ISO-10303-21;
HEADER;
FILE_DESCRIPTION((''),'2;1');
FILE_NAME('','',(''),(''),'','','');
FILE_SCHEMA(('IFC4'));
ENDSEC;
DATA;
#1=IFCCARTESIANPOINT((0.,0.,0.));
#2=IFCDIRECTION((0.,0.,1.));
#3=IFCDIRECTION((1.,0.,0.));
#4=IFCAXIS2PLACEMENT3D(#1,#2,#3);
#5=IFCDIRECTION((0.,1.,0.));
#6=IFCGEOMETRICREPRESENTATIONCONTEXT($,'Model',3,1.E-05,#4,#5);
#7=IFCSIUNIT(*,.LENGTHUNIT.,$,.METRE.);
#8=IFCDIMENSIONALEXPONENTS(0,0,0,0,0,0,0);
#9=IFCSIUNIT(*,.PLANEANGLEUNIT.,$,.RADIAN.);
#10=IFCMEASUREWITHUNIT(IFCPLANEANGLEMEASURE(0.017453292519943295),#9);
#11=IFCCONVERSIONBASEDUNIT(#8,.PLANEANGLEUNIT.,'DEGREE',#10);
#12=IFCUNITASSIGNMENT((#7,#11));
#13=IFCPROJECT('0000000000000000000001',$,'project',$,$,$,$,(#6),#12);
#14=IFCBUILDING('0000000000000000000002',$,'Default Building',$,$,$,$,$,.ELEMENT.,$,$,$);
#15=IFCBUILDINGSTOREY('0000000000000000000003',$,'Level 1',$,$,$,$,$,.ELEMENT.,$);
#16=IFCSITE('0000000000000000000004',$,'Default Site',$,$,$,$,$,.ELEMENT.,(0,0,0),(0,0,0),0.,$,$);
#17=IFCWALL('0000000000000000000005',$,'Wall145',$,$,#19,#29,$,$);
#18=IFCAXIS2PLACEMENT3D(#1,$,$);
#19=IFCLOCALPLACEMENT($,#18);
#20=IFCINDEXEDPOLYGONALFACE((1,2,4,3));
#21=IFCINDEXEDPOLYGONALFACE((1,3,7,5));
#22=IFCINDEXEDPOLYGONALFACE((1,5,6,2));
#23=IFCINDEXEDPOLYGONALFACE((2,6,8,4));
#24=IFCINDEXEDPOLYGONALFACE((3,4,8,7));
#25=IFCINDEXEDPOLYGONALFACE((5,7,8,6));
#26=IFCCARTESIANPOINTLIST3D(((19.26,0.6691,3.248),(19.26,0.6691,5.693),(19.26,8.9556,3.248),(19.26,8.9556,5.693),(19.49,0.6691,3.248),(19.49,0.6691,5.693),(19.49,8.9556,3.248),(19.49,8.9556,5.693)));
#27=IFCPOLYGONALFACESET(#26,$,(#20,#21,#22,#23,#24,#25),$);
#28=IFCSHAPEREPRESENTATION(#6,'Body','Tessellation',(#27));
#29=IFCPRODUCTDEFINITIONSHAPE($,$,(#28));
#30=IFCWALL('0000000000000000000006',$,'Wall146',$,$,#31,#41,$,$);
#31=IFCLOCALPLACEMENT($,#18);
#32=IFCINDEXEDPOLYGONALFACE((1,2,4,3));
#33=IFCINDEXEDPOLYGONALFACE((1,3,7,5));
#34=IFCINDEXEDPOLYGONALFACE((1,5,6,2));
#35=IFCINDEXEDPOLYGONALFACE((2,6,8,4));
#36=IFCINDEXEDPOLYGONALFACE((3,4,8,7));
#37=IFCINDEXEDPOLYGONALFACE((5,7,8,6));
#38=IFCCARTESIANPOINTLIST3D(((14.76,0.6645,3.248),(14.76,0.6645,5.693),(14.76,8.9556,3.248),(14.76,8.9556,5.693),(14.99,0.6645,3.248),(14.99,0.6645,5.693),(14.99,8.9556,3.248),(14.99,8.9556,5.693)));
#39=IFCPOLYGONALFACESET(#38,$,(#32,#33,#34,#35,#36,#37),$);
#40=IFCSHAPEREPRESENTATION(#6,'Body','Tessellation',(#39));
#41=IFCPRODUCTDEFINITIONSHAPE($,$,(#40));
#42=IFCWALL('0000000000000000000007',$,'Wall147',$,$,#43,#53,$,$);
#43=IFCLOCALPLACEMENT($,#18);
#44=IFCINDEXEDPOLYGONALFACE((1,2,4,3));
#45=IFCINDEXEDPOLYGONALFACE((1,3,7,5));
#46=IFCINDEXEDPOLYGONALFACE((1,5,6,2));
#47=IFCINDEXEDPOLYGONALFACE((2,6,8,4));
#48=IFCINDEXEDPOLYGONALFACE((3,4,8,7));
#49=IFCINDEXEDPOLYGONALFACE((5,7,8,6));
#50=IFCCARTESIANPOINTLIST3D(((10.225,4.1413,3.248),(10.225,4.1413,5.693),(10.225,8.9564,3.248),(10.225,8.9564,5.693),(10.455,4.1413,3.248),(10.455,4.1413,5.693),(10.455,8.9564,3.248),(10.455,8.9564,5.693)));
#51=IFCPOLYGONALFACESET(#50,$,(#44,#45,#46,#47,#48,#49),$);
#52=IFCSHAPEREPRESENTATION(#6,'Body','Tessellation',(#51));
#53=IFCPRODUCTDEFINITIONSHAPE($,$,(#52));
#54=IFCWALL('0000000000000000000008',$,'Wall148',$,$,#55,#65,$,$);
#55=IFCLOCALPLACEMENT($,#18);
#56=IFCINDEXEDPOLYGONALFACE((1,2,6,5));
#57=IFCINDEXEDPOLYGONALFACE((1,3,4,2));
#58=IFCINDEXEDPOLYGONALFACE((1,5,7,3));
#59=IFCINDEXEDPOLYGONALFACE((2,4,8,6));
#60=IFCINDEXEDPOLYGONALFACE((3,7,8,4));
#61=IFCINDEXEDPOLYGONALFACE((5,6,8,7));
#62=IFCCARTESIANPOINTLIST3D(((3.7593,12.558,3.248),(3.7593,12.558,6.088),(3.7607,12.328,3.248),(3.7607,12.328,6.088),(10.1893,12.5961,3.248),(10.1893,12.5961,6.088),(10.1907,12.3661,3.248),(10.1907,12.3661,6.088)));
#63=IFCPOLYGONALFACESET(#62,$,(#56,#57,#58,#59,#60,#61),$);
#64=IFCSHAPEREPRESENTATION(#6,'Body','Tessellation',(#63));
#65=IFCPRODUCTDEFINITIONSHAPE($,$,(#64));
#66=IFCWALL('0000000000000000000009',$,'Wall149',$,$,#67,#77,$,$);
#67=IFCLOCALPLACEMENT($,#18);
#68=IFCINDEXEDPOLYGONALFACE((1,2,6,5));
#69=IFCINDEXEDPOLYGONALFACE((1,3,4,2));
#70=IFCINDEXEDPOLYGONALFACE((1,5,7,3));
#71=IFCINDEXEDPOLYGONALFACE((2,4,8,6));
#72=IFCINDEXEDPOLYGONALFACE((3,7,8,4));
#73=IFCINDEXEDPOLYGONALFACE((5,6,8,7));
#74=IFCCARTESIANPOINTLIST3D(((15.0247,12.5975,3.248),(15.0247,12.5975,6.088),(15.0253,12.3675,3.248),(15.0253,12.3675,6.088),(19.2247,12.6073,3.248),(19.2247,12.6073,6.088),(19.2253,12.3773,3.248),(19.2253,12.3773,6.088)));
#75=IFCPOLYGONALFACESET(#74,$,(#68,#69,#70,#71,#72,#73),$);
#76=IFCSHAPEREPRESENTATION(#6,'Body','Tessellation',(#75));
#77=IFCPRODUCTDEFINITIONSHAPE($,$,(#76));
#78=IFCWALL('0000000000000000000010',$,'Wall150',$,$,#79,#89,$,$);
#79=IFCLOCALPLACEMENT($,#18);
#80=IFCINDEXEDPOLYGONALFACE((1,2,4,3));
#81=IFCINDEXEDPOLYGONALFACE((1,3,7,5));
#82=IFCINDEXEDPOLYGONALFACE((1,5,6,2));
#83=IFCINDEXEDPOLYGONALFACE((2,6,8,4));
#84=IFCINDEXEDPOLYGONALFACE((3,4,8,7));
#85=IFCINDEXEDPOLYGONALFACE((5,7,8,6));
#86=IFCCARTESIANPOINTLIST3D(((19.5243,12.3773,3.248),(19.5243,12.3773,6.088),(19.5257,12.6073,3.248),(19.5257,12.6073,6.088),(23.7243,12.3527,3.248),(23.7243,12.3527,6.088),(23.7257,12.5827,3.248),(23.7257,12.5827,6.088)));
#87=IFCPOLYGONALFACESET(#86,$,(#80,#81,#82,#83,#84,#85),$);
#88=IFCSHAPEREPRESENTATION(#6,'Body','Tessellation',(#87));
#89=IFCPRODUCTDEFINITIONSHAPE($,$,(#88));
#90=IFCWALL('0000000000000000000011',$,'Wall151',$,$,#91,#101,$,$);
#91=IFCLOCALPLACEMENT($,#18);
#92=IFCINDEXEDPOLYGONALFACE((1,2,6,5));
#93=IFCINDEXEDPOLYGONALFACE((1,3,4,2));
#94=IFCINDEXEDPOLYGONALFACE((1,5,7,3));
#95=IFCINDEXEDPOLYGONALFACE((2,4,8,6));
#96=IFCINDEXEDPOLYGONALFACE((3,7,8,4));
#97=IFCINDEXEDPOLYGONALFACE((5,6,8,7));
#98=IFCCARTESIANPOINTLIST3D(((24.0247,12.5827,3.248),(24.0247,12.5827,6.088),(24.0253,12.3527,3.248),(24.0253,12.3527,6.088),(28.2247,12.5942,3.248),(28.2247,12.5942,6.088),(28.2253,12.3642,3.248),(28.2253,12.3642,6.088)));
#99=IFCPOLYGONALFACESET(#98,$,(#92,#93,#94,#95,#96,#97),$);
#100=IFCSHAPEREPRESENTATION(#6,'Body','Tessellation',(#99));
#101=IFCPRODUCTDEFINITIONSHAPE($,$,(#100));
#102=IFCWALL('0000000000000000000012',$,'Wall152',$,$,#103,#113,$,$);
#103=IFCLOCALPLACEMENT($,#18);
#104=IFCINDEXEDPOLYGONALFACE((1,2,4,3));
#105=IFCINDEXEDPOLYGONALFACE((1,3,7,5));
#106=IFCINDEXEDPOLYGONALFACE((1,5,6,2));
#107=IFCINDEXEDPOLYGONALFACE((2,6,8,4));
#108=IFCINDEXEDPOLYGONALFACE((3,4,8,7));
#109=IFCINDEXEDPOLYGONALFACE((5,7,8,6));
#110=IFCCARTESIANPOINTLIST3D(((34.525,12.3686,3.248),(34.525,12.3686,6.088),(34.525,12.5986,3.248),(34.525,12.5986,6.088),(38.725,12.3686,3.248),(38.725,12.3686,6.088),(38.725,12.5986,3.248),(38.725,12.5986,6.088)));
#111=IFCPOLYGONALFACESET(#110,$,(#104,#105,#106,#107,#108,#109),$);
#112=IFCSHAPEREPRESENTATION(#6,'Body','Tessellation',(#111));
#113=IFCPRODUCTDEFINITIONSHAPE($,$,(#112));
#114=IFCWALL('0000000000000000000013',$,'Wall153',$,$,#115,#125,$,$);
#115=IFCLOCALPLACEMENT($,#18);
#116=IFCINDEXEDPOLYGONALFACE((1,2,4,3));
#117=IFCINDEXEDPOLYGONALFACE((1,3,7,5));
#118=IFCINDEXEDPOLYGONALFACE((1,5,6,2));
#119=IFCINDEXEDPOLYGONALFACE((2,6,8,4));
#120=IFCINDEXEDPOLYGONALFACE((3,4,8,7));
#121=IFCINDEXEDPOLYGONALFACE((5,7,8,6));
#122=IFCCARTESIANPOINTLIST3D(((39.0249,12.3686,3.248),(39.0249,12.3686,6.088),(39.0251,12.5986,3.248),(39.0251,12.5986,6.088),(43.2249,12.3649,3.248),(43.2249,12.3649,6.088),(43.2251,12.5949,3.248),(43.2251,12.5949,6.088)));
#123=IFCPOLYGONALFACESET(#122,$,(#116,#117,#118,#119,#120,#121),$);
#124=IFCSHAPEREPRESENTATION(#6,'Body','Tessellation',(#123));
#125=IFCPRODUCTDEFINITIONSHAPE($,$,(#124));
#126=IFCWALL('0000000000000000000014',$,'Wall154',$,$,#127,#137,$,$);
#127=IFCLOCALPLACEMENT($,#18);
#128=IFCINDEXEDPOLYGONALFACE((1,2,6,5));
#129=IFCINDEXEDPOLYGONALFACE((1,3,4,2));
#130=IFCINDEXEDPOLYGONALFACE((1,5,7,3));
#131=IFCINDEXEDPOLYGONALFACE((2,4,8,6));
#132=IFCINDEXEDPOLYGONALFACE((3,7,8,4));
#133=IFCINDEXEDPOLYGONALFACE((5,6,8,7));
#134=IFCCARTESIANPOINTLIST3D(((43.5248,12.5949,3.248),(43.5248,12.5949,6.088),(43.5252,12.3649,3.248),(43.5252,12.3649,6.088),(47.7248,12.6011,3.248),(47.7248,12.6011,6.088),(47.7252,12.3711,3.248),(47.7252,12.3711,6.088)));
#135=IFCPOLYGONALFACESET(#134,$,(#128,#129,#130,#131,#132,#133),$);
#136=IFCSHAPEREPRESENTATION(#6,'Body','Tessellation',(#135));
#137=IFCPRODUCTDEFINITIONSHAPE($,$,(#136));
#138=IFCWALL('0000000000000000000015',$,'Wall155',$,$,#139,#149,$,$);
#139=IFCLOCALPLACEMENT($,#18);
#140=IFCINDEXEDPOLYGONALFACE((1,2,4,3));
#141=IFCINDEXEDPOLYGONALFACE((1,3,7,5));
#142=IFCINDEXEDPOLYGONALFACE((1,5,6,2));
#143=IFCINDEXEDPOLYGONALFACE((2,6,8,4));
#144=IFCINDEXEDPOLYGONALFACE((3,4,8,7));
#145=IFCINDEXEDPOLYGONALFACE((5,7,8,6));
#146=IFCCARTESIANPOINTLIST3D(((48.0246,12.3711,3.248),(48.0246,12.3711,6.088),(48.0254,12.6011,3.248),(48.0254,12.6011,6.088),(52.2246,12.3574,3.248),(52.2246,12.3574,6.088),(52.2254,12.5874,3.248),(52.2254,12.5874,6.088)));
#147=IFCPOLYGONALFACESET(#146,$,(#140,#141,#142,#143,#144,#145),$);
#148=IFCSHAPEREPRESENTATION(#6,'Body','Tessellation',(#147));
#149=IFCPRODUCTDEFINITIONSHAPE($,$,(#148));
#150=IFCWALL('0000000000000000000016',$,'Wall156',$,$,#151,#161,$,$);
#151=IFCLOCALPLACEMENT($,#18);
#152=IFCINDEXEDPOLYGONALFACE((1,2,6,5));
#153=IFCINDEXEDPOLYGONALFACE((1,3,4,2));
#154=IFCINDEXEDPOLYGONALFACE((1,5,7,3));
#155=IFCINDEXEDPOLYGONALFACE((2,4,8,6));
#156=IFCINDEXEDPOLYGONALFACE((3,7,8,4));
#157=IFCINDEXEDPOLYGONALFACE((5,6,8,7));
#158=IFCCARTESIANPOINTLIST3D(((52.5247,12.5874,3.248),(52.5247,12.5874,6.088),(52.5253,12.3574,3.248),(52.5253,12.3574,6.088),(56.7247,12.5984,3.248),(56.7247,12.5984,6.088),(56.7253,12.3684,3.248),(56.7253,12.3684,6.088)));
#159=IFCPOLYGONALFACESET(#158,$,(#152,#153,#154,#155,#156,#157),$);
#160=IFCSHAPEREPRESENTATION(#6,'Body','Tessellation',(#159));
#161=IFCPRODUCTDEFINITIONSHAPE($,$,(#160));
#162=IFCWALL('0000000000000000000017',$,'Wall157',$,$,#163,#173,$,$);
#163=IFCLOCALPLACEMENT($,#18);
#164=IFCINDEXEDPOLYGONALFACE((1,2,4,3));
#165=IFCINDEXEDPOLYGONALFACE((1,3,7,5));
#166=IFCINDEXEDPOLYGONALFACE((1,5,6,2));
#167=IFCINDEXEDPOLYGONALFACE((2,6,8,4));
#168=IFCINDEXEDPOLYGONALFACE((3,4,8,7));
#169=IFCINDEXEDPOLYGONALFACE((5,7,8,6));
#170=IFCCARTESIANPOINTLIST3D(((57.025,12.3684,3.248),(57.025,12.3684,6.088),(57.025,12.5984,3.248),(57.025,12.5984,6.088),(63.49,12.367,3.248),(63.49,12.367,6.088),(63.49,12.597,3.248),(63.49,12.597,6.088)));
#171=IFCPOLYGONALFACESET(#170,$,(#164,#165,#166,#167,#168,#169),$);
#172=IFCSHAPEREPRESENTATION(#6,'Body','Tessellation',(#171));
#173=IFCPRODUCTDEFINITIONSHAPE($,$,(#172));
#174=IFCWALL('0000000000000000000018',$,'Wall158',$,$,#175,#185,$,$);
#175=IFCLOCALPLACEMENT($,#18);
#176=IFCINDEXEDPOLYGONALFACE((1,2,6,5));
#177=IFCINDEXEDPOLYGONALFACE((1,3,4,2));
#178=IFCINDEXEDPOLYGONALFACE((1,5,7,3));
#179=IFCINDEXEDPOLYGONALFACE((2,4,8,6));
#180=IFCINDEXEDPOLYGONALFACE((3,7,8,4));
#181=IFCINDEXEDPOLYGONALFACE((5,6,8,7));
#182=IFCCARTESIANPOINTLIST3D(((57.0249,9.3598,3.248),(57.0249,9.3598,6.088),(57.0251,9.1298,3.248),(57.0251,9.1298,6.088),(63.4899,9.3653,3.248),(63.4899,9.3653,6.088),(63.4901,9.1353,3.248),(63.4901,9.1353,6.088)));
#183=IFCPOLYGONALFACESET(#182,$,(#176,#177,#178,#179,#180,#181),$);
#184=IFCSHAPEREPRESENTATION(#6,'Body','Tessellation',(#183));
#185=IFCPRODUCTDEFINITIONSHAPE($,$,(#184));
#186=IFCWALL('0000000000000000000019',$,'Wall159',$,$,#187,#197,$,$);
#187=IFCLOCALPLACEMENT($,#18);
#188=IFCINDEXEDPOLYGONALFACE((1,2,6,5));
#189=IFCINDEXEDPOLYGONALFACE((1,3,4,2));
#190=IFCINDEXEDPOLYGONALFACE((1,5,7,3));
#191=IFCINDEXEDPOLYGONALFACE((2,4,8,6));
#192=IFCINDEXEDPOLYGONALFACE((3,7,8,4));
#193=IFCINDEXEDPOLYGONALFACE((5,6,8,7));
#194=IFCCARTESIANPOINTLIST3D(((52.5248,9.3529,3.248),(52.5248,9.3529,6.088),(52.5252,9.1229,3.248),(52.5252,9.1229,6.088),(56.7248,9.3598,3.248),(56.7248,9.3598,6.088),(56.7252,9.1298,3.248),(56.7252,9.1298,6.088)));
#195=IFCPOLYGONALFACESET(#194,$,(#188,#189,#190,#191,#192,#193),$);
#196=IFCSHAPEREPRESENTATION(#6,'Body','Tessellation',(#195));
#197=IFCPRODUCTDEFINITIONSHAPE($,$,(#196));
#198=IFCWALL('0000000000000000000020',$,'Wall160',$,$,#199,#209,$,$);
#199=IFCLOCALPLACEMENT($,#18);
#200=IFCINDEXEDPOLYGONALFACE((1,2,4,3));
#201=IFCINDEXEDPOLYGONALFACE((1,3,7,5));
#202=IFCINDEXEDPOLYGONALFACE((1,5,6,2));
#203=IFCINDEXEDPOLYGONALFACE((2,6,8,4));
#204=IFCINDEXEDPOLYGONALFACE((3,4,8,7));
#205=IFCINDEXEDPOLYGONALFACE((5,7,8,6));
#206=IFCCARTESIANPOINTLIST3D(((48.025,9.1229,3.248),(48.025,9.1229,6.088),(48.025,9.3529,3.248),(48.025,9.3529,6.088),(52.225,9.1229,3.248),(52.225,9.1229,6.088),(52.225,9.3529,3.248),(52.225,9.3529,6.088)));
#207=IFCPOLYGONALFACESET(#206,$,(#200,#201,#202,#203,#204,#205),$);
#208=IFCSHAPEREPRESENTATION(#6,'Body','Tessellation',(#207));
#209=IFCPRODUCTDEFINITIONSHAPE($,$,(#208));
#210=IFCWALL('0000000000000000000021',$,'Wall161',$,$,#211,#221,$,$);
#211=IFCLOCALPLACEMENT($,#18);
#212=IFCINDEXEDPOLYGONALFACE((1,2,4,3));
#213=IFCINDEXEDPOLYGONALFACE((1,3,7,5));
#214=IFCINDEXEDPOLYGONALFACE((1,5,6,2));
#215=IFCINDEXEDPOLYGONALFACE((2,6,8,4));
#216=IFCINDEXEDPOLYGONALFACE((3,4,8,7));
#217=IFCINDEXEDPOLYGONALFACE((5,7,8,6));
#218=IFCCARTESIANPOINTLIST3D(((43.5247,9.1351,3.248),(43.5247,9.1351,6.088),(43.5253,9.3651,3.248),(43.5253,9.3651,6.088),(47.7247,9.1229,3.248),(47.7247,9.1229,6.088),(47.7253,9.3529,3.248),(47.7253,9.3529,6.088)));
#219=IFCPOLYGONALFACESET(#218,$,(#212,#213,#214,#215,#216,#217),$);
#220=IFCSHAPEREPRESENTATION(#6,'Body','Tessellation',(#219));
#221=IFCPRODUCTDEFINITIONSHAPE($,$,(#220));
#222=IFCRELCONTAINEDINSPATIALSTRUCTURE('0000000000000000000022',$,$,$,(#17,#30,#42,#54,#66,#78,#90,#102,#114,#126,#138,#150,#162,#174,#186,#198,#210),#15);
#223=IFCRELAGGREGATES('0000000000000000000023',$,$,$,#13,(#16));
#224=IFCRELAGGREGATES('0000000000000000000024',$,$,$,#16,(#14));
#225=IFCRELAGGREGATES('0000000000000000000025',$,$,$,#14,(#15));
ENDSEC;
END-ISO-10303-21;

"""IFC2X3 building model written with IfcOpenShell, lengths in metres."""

from ifc_helpers import new_model, entity, si_unit, converted_unit, direction, frame, frame_2d, origin_with_axes, place, context, project, spatial, rectangle, extrude, element, save


model = new_model("IFC2X3")

# Units and contexts
model_context = context("Model", 3, precision=1e-05, world=origin_with_axes(), true_north=direction((0.0, 1.0, 0.0)))
ifc_project = project(units=[si_unit("LENGTHUNIT", "METRE"), converted_unit("PLANEANGLEUNIT", "DEGREE", entity("IfcPlaneAngleMeasure", 0.017453292519943295), si_unit("PLANEANGLEUNIT", "RADIAN"), dimensions=[0, 0, 0, 0, 0, 0, 0])], contexts=[model_context])

# Site, building, storey
site = spatial("IfcSite", under=ifc_project, Name="Default Site", CompositionType="ELEMENT", RefLatitude=(0, 0, 0), RefLongitude=(0, 0, 0), RefElevation=0.0)
building = spatial("IfcBuilding", under=site, Name="Default Building", CompositionType="ELEMENT")
storey = spatial("IfcBuildingStorey", under=building, Name="Level 1", CompositionType="ELEMENT")

# Walls
placement = place(None, origin_with_axes())
element("IfcWall", 1, at=placement, inside=storey, Name="Wall145", context=model_context, shape_type="SweptSolid", body=[
    extrude(rectangle(XDim=8.2866, YDim=0.23, at=frame_2d((0.0, 0.0), x_axis=(0.0, 1.0, 0.0))), frame((19.375, 4.8124, 3.248), z_axis=(0.0, 0.0, 1.0), x_axis=(1.0, 0.0, 0.0)), (0.0, 0.0, 1.0), 2.445),
])
element("IfcWall", 2, at=placement, inside=storey, Name="Wall146", context=model_context, shape_type="SweptSolid", body=[
    extrude(rectangle(XDim=8.291, YDim=0.23, at=frame_2d((0.0, 0.0), x_axis=(0.0, -1.0, 0.0))), frame((14.875, 4.81, 3.248), z_axis=(0.0, 0.0, 1.0), x_axis=(1.0, 0.0, 0.0)), (0.0, 0.0, 1.0), 2.445),
])
element("IfcWall", 3, at=placement, inside=storey, Name="Wall147", context=model_context, shape_type="SweptSolid", body=[
    extrude(rectangle(XDim=4.8151, YDim=0.23, at=frame_2d((0.0, 0.0), x_axis=(0.0, 1.0, 0.0))), frame((10.34, 6.5488, 3.248), z_axis=(0.0, 0.0, 1.0), x_axis=(1.0, 0.0, 0.0)), (0.0, 0.0, 1.0), 2.445),
])
element("IfcWall", 4, at=placement, inside=storey, Name="Wall148", context=model_context, shape_type="SweptSolid", body=[
    extrude(rectangle(XDim=6.4301, YDim=0.23, at=frame_2d((0.0, 0.0), x_axis=(0.999982, 0.005918, 0.0))), frame((6.975, 12.4621, 3.248), z_axis=(0.0, 0.0, 1.0), x_axis=(1.0, 0.0, 0.0)), (0.0, 0.0, 1.0), 2.84),
])
element("IfcWall", 5, at=placement, inside=storey, Name="Wall149", context=model_context, shape_type="SweptSolid", body=[
    extrude(rectangle(XDim=4.2, YDim=0.23, at=frame_2d((0.0, 0.0), x_axis=(-0.999997, -0.002332, 0.0))), frame((17.125, 12.4874, 3.248), z_axis=(0.0, 0.0, 1.0), x_axis=(1.0, 0.0, 0.0)), (0.0, 0.0, 1.0), 2.84),
])
element("IfcWall", 6, at=placement, inside=storey, Name="Wall150", context=model_context, shape_type="SweptSolid", body=[
    extrude(rectangle(XDim=4.2001, YDim=0.23, at=frame_2d((0.0, 0.0), x_axis=(0.999983, -0.005853, 0.0))), frame((21.625, 12.48, 3.248), z_axis=(0.0, 0.0, 1.0), x_axis=(1.0, 0.0, 0.0)), (0.0, 0.0, 1.0), 2.84),
])
element("IfcWall", 7, at=placement, inside=storey, Name="Wall151", context=model_context, shape_type="SweptSolid", body=[
    extrude(rectangle(XDim=4.2, YDim=0.23, at=frame_2d((0.0, 0.0), x_axis=(-0.999996, -0.002734, 0.0))), frame((26.125, 12.4734, 3.248), z_axis=(0.0, 0.0, 1.0), x_axis=(1.0, 0.0, 0.0)), (0.0, 0.0, 1.0), 2.84),
])
element("IfcWall", 8, at=placement, inside=storey, Name="Wall152", context=model_context, shape_type="SweptSolid", body=[
    extrude(rectangle(XDim=4.2, YDim=0.23, at=frame_2d((0.0, 0.0), x_axis=(-1.0, 0.000008, 0.0))), frame((36.625, 12.4836, 3.248), z_axis=(0.0, 0.0, 1.0), x_axis=(1.0, 0.0, 0.0)), (0.0, 0.0, 1.0), 2.84),
])
element("IfcWall", 9, at=placement, inside=storey, Name="Wall153", context=model_context, shape_type="SweptSolid", body=[
    extrude(rectangle(XDim=4.2, YDim=0.23, at=frame_2d((0.0, 0.0), x_axis=(1.0, -0.000885, 0.0))), frame((41.125, 12.4817, 3.248), z_axis=(0.0, 0.0, 1.0), x_axis=(1.0, 0.0, 0.0)), (0.0, 0.0, 1.0), 2.84),
])
element("IfcWall", 10, at=placement, inside=storey, Name="Wall154", context=model_context, shape_type="SweptSolid", body=[
    extrude(rectangle(XDim=4.2, YDim=0.23, at=frame_2d((0.0, 0.0), x_axis=(-0.999999, -0.001472, 0.0))), frame((45.625, 12.483, 3.248), z_axis=(0.0, 0.0, 1.0), x_axis=(1.0, 0.0, 0.0)), (0.0, 0.0, 1.0), 2.84),
])
element("IfcWall", 11, at=placement, inside=storey, Name="Wall155", context=model_context, shape_type="SweptSolid", body=[
    extrude(rectangle(XDim=4.2, YDim=0.23, at=frame_2d((0.0, 0.0), x_axis=(0.999995, -0.003262, 0.0))), frame((50.125, 12.4792, 3.248), z_axis=(0.0, 0.0, 1.0), x_axis=(1.0, 0.0, 0.0)), (0.0, 0.0, 1.0), 2.84),
])
element("IfcWall", 12, at=placement, inside=storey, Name="Wall156", context=model_context, shape_type="SweptSolid", body=[
    extrude(rectangle(XDim=4.2, YDim=0.23, at=frame_2d((0.0, 0.0), x_axis=(-0.999997, -0.002631, 0.0))), frame((54.625, 12.4779, 3.248), z_axis=(0.0, 0.0, 1.0), x_axis=(1.0, 0.0, 0.0)), (0.0, 0.0, 1.0), 2.84),
])
element("IfcWall", 13, at=placement, inside=storey, Name="Wall157", context=model_context, shape_type="SweptSolid", body=[
    extrude(rectangle(XDim=6.465, YDim=0.23, at=frame_2d((0.0, 0.0), x_axis=(1.0, -0.000226, 0.0))), frame((60.2575, 12.4827, 3.248), z_axis=(0.0, 0.0, 1.0), x_axis=(1.0, 0.0, 0.0)), (0.0, 0.0, 1.0), 2.84),
])
element("IfcWall", 14, at=placement, inside=storey, Name="Wall158", context=model_context, shape_type="SweptSolid", body=[
    extrude(rectangle(XDim=6.465, YDim=0.23, at=frame_2d((0.0, 0.0), x_axis=(-1.0, -0.000853, 0.0))), frame((60.2575, 9.2476, 3.248), z_axis=(0.0, 0.0, 1.0), x_axis=(1.0, 0.0, 0.0)), (0.0, 0.0, 1.0), 2.84),
])
element("IfcWall", 15, at=placement, inside=storey, Name="Wall159", context=model_context, shape_type="SweptSolid", body=[
    extrude(rectangle(XDim=4.2, YDim=0.23, at=frame_2d((0.0, 0.0), x_axis=(0.999999, 0.001646, 0.0))), frame((54.625, 9.2414, 3.248), z_axis=(0.0, 0.0, 1.0), x_axis=(1.0, 0.0, 0.0)), (0.0, 0.0, 1.0), 2.84),
])
element("IfcWall", 16, at=placement, inside=storey, Name="Wall160", context=model_context, shape_type="SweptSolid", body=[
    extrude(rectangle(XDim=4.2, YDim=0.23, at=frame_2d((0.0, 0.0), x_axis=(-1.0, 0.0, 0.0))), frame((50.125, 9.2379, 3.248), z_axis=(0.0, 0.0, 1.0), x_axis=(1.0, 0.0, 0.0)), (0.0, 0.0, 1.0), 2.84),
])
element("IfcWall", 17, at=placement, inside=storey, Name="Wall161", context=model_context, shape_type="SweptSolid", body=[
    extrude(rectangle(XDim=4.2, YDim=0.23, at=frame_2d((0.0, 0.0), x_axis=(0.999996, -0.002895, 0.0))), frame((45.625, 9.244, 3.248), z_axis=(0.0, 0.0, 1.0), x_axis=(1.0, 0.0, 0.0)), (0.0, 0.0, 1.0), 2.84),
])

save(model, "model.ifc")
